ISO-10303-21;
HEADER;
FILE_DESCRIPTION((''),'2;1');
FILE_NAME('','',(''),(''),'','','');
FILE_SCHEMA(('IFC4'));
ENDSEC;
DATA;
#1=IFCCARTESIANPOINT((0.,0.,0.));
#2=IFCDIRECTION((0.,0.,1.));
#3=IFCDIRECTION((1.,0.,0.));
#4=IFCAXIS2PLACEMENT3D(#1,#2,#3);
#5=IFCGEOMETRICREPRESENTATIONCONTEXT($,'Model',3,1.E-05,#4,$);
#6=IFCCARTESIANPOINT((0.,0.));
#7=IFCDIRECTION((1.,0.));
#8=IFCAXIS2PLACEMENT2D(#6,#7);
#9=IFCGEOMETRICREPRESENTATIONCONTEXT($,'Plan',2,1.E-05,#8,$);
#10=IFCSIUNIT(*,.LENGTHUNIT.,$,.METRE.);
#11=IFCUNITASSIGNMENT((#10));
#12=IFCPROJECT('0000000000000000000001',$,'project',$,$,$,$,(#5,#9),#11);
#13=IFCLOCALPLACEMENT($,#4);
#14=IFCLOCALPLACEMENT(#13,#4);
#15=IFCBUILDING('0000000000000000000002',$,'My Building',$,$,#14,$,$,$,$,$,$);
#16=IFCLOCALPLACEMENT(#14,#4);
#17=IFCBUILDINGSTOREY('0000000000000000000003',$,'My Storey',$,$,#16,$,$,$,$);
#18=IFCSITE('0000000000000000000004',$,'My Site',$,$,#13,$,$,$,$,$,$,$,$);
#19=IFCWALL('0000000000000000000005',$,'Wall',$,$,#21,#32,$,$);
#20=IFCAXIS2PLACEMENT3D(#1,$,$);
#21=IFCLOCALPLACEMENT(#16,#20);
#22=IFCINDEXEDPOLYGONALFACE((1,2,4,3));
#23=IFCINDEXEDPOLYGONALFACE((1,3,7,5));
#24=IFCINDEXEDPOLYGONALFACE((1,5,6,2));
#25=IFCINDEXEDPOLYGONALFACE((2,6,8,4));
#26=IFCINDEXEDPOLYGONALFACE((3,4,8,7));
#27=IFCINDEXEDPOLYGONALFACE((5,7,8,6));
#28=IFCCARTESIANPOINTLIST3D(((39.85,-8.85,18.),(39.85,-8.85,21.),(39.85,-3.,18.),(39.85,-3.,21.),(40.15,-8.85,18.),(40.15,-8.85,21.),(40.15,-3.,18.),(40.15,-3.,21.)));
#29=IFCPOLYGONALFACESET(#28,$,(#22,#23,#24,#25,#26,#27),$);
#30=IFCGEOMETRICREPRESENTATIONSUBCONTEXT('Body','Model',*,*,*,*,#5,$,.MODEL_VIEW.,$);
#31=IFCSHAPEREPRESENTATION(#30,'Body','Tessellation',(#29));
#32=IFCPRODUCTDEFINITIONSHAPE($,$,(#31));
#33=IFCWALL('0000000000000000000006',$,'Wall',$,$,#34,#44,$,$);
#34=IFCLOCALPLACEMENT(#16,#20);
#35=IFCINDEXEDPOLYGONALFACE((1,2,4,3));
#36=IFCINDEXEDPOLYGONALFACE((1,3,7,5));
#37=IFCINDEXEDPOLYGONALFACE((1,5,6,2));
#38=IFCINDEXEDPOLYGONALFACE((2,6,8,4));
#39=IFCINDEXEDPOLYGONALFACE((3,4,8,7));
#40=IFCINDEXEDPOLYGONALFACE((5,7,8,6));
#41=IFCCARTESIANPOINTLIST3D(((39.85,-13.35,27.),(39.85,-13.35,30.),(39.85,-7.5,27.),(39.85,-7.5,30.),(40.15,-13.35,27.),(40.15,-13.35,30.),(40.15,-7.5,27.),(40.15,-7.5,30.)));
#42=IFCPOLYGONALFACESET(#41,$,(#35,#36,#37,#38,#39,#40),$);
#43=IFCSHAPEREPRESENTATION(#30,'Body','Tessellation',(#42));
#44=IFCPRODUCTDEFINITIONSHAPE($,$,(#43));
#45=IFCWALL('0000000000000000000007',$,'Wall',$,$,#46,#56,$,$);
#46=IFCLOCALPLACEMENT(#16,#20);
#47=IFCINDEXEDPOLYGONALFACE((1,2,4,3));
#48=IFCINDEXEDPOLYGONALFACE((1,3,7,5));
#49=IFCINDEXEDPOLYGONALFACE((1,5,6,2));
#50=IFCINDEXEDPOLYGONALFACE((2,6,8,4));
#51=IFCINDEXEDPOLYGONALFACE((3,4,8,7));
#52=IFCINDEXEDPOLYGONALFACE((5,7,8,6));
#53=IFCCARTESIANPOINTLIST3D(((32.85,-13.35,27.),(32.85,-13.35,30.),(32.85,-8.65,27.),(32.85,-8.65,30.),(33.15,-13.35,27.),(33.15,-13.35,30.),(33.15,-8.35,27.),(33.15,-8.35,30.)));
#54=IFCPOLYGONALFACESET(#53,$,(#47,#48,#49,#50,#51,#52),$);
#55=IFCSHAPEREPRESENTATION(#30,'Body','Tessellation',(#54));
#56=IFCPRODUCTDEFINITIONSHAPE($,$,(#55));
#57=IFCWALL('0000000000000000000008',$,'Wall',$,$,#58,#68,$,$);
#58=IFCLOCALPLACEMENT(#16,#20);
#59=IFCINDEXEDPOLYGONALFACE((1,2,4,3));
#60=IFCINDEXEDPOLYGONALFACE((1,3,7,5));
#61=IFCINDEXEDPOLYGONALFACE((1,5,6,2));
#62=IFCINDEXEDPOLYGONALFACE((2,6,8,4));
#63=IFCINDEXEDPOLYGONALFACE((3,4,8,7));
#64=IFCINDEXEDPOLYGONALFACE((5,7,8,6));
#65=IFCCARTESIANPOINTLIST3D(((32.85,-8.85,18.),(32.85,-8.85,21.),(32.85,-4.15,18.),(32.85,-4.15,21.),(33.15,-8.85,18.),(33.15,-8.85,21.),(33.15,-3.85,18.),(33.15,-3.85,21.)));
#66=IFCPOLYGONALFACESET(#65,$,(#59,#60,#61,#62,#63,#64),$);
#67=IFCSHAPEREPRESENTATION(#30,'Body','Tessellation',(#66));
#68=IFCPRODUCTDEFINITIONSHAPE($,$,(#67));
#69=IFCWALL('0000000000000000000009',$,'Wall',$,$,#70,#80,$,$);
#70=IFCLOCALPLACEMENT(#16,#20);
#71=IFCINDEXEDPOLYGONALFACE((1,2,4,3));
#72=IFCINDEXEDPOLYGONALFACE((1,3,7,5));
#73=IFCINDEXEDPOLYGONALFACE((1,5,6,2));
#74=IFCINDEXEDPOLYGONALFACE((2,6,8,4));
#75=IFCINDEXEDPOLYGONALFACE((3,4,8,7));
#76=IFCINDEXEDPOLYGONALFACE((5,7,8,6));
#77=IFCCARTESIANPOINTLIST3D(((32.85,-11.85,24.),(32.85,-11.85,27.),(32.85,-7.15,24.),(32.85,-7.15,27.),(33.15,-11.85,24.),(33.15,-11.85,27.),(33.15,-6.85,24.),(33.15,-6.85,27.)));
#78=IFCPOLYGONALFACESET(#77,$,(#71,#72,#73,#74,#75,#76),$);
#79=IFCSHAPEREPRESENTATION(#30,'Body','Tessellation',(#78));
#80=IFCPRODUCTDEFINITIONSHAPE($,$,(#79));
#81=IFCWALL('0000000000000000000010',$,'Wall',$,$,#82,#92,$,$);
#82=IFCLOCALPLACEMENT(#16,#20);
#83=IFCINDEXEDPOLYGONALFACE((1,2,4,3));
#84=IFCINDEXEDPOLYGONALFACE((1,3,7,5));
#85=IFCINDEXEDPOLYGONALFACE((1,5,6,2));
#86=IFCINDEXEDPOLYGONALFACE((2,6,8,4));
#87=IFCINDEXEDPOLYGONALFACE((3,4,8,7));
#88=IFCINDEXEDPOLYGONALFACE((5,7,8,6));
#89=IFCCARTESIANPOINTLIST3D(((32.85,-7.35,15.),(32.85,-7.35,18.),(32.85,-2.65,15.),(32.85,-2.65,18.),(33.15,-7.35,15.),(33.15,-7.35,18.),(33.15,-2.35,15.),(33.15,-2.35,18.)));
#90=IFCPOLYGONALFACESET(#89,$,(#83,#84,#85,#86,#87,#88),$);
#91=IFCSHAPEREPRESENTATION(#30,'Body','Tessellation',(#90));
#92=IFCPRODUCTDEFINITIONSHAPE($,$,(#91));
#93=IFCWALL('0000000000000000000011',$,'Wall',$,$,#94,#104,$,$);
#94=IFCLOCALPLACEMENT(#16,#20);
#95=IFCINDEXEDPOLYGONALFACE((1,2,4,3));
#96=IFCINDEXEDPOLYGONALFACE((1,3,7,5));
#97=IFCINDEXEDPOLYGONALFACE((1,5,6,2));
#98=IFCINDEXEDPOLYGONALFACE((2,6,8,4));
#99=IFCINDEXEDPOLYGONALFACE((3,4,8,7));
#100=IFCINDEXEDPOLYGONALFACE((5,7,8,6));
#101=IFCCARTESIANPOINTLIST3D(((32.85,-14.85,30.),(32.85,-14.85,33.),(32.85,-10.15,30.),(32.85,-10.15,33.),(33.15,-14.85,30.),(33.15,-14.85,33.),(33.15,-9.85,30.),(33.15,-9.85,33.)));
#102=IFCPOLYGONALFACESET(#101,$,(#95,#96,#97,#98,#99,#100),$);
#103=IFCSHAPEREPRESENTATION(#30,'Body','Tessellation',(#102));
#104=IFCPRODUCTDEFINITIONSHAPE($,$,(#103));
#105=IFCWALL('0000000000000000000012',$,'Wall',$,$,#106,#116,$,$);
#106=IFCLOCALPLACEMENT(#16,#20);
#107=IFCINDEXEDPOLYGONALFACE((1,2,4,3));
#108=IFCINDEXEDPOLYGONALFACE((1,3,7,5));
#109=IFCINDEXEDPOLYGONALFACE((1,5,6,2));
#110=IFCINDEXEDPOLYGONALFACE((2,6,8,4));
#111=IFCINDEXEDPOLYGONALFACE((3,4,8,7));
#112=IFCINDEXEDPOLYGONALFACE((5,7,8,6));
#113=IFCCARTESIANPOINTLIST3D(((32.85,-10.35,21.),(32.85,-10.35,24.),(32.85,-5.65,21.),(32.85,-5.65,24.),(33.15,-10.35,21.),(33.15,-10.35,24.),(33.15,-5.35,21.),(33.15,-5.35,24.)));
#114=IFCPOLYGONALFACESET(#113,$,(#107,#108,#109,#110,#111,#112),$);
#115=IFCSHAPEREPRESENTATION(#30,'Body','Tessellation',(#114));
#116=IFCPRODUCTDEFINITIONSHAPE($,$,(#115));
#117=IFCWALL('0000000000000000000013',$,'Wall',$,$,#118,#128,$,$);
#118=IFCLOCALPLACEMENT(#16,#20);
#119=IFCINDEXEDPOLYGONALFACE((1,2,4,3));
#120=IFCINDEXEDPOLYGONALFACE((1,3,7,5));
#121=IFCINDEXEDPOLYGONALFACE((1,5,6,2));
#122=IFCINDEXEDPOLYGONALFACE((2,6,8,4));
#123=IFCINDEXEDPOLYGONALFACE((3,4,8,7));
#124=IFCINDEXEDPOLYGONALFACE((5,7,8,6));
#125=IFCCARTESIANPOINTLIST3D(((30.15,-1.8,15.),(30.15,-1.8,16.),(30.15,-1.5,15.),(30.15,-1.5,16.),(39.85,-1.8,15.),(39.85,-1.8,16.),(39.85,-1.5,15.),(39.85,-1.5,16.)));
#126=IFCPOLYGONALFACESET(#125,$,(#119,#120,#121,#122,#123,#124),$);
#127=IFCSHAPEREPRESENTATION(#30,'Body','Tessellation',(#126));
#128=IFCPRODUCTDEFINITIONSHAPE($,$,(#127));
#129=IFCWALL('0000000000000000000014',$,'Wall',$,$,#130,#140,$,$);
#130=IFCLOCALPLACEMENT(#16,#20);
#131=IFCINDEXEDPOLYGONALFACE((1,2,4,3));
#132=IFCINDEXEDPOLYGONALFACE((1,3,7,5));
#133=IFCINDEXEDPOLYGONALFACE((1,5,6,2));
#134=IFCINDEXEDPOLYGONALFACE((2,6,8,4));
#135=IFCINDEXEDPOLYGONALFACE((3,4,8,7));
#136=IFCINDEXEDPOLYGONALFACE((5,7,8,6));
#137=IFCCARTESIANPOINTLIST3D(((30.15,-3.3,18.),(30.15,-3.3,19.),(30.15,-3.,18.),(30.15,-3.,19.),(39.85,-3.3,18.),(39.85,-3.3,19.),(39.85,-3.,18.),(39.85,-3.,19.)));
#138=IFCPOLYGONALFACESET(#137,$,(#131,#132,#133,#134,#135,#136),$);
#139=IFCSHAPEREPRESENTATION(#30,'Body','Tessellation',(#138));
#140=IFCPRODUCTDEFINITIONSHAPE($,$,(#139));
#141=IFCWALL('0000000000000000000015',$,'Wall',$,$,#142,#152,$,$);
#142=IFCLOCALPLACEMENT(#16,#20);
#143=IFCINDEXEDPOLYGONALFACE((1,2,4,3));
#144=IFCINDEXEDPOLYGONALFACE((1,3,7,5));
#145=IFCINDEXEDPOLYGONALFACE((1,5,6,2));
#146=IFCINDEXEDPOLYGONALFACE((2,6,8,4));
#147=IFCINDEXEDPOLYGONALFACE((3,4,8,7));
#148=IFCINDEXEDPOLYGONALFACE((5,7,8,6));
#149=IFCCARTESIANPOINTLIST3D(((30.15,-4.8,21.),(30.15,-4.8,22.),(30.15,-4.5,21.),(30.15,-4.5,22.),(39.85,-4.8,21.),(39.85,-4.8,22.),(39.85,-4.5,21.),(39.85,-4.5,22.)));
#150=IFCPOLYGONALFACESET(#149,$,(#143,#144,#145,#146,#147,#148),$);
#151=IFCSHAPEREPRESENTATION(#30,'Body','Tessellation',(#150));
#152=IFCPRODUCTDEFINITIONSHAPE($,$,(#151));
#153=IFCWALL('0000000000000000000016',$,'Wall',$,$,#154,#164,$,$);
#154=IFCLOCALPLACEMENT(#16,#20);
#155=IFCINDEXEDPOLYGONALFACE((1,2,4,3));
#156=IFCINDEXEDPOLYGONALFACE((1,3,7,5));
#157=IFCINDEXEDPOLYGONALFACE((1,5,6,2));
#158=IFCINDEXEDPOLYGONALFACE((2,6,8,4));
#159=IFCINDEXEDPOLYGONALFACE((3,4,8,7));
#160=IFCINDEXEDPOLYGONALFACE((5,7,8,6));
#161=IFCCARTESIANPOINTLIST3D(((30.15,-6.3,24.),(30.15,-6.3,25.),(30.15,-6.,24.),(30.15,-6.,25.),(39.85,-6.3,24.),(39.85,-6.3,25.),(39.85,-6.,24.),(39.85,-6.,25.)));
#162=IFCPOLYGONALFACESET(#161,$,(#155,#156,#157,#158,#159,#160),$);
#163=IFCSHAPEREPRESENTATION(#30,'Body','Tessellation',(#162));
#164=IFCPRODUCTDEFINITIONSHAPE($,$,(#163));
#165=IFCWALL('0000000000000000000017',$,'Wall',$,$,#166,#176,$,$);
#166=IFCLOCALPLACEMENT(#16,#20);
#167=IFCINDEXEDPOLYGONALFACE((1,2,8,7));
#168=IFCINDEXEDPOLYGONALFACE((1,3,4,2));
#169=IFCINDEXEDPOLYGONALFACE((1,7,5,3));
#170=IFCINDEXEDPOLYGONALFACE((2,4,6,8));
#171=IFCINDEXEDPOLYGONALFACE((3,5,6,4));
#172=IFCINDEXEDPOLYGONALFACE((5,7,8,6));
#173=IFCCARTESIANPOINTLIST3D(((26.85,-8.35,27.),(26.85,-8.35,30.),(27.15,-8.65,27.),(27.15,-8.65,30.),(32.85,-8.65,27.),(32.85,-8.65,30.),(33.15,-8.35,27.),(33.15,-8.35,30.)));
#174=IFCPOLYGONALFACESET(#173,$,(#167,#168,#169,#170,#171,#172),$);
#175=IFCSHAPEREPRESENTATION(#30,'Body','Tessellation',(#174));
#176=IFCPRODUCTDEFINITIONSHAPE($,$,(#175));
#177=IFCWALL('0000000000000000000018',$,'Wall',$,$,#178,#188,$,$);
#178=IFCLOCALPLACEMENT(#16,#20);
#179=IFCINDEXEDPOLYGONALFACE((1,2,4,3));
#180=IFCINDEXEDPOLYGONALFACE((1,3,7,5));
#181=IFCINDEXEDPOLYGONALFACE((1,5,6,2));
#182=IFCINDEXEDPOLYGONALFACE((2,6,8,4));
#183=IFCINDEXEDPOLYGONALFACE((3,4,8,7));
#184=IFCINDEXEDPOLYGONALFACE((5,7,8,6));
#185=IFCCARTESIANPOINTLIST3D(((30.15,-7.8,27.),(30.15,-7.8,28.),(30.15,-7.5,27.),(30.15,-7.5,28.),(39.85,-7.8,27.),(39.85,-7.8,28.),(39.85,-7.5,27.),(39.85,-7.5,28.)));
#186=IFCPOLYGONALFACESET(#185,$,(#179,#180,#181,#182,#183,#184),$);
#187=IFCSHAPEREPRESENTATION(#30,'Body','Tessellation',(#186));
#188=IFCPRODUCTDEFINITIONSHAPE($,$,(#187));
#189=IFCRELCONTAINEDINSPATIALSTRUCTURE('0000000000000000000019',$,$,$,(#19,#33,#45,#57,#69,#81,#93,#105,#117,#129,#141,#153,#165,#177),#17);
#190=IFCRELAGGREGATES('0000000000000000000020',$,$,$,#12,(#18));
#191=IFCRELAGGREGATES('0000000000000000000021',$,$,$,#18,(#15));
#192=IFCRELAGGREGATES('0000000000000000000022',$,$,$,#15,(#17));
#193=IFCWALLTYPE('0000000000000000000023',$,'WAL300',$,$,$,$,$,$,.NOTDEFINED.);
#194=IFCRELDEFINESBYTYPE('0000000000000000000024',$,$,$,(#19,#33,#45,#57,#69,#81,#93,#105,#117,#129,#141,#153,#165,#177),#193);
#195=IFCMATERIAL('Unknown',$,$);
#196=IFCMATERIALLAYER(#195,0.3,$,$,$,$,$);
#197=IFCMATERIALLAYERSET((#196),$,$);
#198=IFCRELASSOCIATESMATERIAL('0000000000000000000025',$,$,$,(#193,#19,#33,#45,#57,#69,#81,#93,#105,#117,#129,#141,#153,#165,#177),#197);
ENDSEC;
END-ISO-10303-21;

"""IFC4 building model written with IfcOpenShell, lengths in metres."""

from ifc_helpers import new_model, si_unit, frame, origin_with_axes, origin_2d_with_axis, place, context, subcontext, project, spatial, line, indexed_curve, outline, extrude, material, layer, layer_set, layer_usage, type_object, element, save


model = new_model("IFC4")

# Units and contexts
model_context = context("Model", 3, precision=1e-05, world=origin_with_axes())
plan_context = context("Plan", 2, precision=1e-05, world=origin_2d_with_axis())
body_context = subcontext(model_context, "Body", "Model", "MODEL_VIEW")
ifc_project = project(units=[si_unit("LENGTHUNIT", "METRE")], contexts=[model_context, plan_context])

# Site, building, storey
site_placement = place(None, origin_with_axes())
site = spatial("IfcSite", under=ifc_project, at=site_placement, Name="My Site")
building_placement = place(site_placement, origin_with_axes())
building = spatial("IfcBuilding", under=site, at=building_placement, Name="My Building")
storey_placement = place(building_placement, origin_with_axes())
storey = spatial("IfcBuildingStorey", under=building, at=storey_placement, Name="My Storey")

# Shared definitions
ifc_material = material(Name="Unknown")

# Walls
ifc_layer_1 = layer(ifc_material, 0.3)
ifc_layer_set_1 = layer_set([ifc_layer_1])
wall_type = type_object("IfcWallType", Name="WAL300", PredefinedType="NOTDEFINED", material=ifc_layer_set_1)
ifc_layer_usage_1 = layer_usage(ifc_layer_set_1, "AXIS2", "POSITIVE", -0.15)
wall_1_placement = place(storey_placement, frame((40.0, -9.0, 18.0), z_axis=(0.0, 0.0, 1.0), x_axis=(0.0, 1.0, 0.0)))
element("IfcWall", 1, at=wall_1_placement, inside=storey, type_object=wall_type, material=ifc_layer_usage_1, Name="Wall", context=body_context, shape_type="SweptSolid", body=[
    extrude(outline(indexed_curve([(0.15, -0.15), (0.15, 0.15), (6.0, 0.15), (6.0, -0.15)], segments=[line(1, 2, 3, 4, 1)])), origin_with_axes(), (0.0, 0.0, 1.0), 3.0),
])
ifc_layer_usage_2 = layer_usage(ifc_layer_set_1, "AXIS2", "POSITIVE", -0.15)
wall_2_placement = place(storey_placement, frame((40.0, -13.5, 27.0), z_axis=(0.0, 0.0, 1.0), x_axis=(0.0, 1.0, 0.0)))
element("IfcWall", 2, at=wall_2_placement, inside=storey, type_object=wall_type, material=ifc_layer_usage_2, Name="Wall", context=body_context, shape_type="SweptSolid", body=[
    extrude(outline(indexed_curve([(0.15, -0.15), (0.15, 0.15), (6.0, 0.15), (6.0, -0.15)], segments=[line(1, 2, 3, 4, 1)])), origin_with_axes(), (0.0, 0.0, 1.0), 3.0),
])
ifc_layer_usage_3 = layer_usage(ifc_layer_set_1, "AXIS2", "POSITIVE", -0.15)
wall_3_placement = place(storey_placement, frame((33.0, -13.5, 27.0), z_axis=(0.0, 0.0, 1.0), x_axis=(0.0, 1.0, 0.0)))
element("IfcWall", 3, at=wall_3_placement, inside=storey, type_object=wall_type, material=ifc_layer_usage_3, Name="Wall", context=body_context, shape_type="SweptSolid", body=[
    extrude(outline(indexed_curve([(0.15, -0.15), (0.15, 0.15), (4.85, 0.15), (5.15, -0.15)], segments=[line(1, 2, 3, 4, 1)])), origin_with_axes(), (0.0, 0.0, 1.0), 3.0),
])
ifc_layer_usage_4 = layer_usage(ifc_layer_set_1, "AXIS2", "POSITIVE", -0.15)
wall_4_placement = place(storey_placement, frame((33.0, -9.0, 18.0), z_axis=(0.0, 0.0, 1.0), x_axis=(0.0, 1.0, 0.0)))
element("IfcWall", 4, at=wall_4_placement, inside=storey, type_object=wall_type, material=ifc_layer_usage_4, Name="Wall", context=body_context, shape_type="SweptSolid", body=[
    extrude(outline(indexed_curve([(0.15, -0.15), (0.15, 0.15), (4.85, 0.15), (5.15, -0.15)], segments=[line(1, 2, 3, 4, 1)])), origin_with_axes(), (0.0, 0.0, 1.0), 3.0),
])
ifc_layer_usage_5 = layer_usage(ifc_layer_set_1, "AXIS2", "POSITIVE", -0.15)
wall_5_placement = place(storey_placement, frame((33.0, -12.0, 24.0), z_axis=(0.0, 0.0, 1.0), x_axis=(0.0, 1.0, 0.0)))
element("IfcWall", 5, at=wall_5_placement, inside=storey, type_object=wall_type, material=ifc_layer_usage_5, Name="Wall", context=body_context, shape_type="SweptSolid", body=[
    extrude(outline(indexed_curve([(0.15, -0.15), (0.15, 0.15), (4.85, 0.15), (5.15, -0.15)], segments=[line(1, 2, 3, 4, 1)])), origin_with_axes(), (0.0, 0.0, 1.0), 3.0),
])
ifc_layer_usage_6 = layer_usage(ifc_layer_set_1, "AXIS2", "POSITIVE", -0.15)
wall_6_placement = place(storey_placement, frame((33.0, -7.5, 15.0), z_axis=(0.0, 0.0, 1.0), x_axis=(0.0, 1.0, 0.0)))
element("IfcWall", 6, at=wall_6_placement, inside=storey, type_object=wall_type, material=ifc_layer_usage_6, Name="Wall", context=body_context, shape_type="SweptSolid", body=[
    extrude(outline(indexed_curve([(0.15, -0.15), (0.15, 0.15), (4.85, 0.15), (5.15, -0.15)], segments=[line(1, 2, 3, 4, 1)])), origin_with_axes(), (0.0, 0.0, 1.0), 3.0),
])
ifc_layer_usage_7 = layer_usage(ifc_layer_set_1, "AXIS2", "POSITIVE", -0.15)
wall_7_placement = place(storey_placement, frame((33.0, -15.0, 30.0), z_axis=(0.0, 0.0, 1.0), x_axis=(0.0, 1.0, 0.0)))
element("IfcWall", 7, at=wall_7_placement, inside=storey, type_object=wall_type, material=ifc_layer_usage_7, Name="Wall", context=body_context, shape_type="SweptSolid", body=[
    extrude(outline(indexed_curve([(0.15, -0.15), (0.15, 0.15), (4.85, 0.15), (5.15, -0.15)], segments=[line(1, 2, 3, 4, 1)])), origin_with_axes(), (0.0, 0.0, 1.0), 3.0),
])
ifc_layer_usage_8 = layer_usage(ifc_layer_set_1, "AXIS2", "POSITIVE", -0.15)
wall_8_placement = place(storey_placement, frame((33.0, -10.5, 21.0), z_axis=(0.0, 0.0, 1.0), x_axis=(0.0, 1.0, 0.0)))
element("IfcWall", 8, at=wall_8_placement, inside=storey, type_object=wall_type, material=ifc_layer_usage_8, Name="Wall", context=body_context, shape_type="SweptSolid", body=[
    extrude(outline(indexed_curve([(0.15, -0.15), (0.15, 0.15), (4.85, 0.15), (5.15, -0.15)], segments=[line(1, 2, 3, 4, 1)])), origin_with_axes(), (0.0, 0.0, 1.0), 3.0),
])
ifc_layer_usage_9 = layer_usage(ifc_layer_set_1, "AXIS2", "POSITIVE", -0.3)
wall_9_placement = place(storey_placement, frame((30.15, -1.5, 15.0), z_axis=(0.0, 0.0, 1.0), x_axis=(1.0, 0.0, 0.0)))
element("IfcWall", 9, at=wall_9_placement, inside=storey, type_object=wall_type, material=ifc_layer_usage_9, Name="Wall", context=body_context, shape_type="SweptSolid", body=[
    extrude(outline(indexed_curve([(0.0, -0.3), (0.0, 0.0), (9.7, 0.0), (9.7, -0.3)], segments=[line(1, 2, 3, 4, 1)])), origin_with_axes(), (0.0, 0.0, 1.0), 1.0),
])
ifc_layer_usage_10 = layer_usage(ifc_layer_set_1, "AXIS2", "POSITIVE", -0.3)
wall_10_placement = place(storey_placement, frame((30.15, -3.0, 18.0), z_axis=(0.0, 0.0, 1.0), x_axis=(1.0, 0.0, 0.0)))
element("IfcWall", 10, at=wall_10_placement, inside=storey, type_object=wall_type, material=ifc_layer_usage_10, Name="Wall", context=body_context, shape_type="SweptSolid", body=[
    extrude(outline(indexed_curve([(0.0, -0.3), (0.0, 0.0), (9.7, 0.0), (9.7, -0.3)], segments=[line(1, 2, 3, 4, 1)])), origin_with_axes(), (0.0, 0.0, 1.0), 1.0),
])
ifc_layer_usage_11 = layer_usage(ifc_layer_set_1, "AXIS2", "POSITIVE", -0.3)
wall_11_placement = place(storey_placement, frame((30.15, -4.5, 21.0), z_axis=(0.0, 0.0, 1.0), x_axis=(1.0, 0.0, 0.0)))
element("IfcWall", 11, at=wall_11_placement, inside=storey, type_object=wall_type, material=ifc_layer_usage_11, Name="Wall", context=body_context, shape_type="SweptSolid", body=[
    extrude(outline(indexed_curve([(0.0, -0.3), (0.0, 0.0), (9.7, 0.0), (9.7, -0.3)], segments=[line(1, 2, 3, 4, 1)])), origin_with_axes(), (0.0, 0.0, 1.0), 1.0),
])
ifc_layer_usage_12 = layer_usage(ifc_layer_set_1, "AXIS2", "POSITIVE", -0.3)
wall_12_placement = place(storey_placement, frame((30.15, -6.0, 24.0), z_axis=(0.0, 0.0, 1.0), x_axis=(1.0, 0.0, 0.0)))
element("IfcWall", 12, at=wall_12_placement, inside=storey, type_object=wall_type, material=ifc_layer_usage_12, Name="Wall", context=body_context, shape_type="SweptSolid", body=[
    extrude(outline(indexed_curve([(0.0, -0.3), (0.0, 0.0), (9.7, 0.0), (9.7, -0.3)], segments=[line(1, 2, 3, 4, 1)])), origin_with_axes(), (0.0, 0.0, 1.0), 1.0),
])
ifc_layer_usage_13 = layer_usage(ifc_layer_set_1, "AXIS2", "POSITIVE", -0.15)
wall_13_placement = place(storey_placement, frame((27.0, -8.5, 27.0), z_axis=(0.0, 0.0, 1.0), x_axis=(1.0, 0.0, 0.0)))
element("IfcWall", 13, at=wall_13_placement, inside=storey, type_object=wall_type, material=ifc_layer_usage_13, Name="Wall", context=body_context, shape_type="SweptSolid", body=[
    extrude(outline(indexed_curve([(0.15, -0.15), (-0.15, 0.15), (6.15, 0.15), (5.85, -0.15)], segments=[line(1, 2, 3, 4, 1)])), origin_with_axes(), (0.0, 0.0, 1.0), 3.0),
])
ifc_layer_usage_14 = layer_usage(ifc_layer_set_1, "AXIS2", "POSITIVE", -0.3)
wall_14_placement = place(storey_placement, frame((30.15, -7.5, 27.0), z_axis=(0.0, 0.0, 1.0), x_axis=(1.0, 0.0, 0.0)))
element("IfcWall", 14, at=wall_14_placement, inside=storey, type_object=wall_type, material=ifc_layer_usage_14, Name="Wall", context=body_context, shape_type="SweptSolid", body=[
    extrude(outline(indexed_curve([(0.0, -0.3), (0.0, 0.0), (9.7, 0.0), (9.7, -0.3)], segments=[line(1, 2, 3, 4, 1)])), origin_with_axes(), (0.0, 0.0, 1.0), 1.0),
])

save(model, "model.ifc")
